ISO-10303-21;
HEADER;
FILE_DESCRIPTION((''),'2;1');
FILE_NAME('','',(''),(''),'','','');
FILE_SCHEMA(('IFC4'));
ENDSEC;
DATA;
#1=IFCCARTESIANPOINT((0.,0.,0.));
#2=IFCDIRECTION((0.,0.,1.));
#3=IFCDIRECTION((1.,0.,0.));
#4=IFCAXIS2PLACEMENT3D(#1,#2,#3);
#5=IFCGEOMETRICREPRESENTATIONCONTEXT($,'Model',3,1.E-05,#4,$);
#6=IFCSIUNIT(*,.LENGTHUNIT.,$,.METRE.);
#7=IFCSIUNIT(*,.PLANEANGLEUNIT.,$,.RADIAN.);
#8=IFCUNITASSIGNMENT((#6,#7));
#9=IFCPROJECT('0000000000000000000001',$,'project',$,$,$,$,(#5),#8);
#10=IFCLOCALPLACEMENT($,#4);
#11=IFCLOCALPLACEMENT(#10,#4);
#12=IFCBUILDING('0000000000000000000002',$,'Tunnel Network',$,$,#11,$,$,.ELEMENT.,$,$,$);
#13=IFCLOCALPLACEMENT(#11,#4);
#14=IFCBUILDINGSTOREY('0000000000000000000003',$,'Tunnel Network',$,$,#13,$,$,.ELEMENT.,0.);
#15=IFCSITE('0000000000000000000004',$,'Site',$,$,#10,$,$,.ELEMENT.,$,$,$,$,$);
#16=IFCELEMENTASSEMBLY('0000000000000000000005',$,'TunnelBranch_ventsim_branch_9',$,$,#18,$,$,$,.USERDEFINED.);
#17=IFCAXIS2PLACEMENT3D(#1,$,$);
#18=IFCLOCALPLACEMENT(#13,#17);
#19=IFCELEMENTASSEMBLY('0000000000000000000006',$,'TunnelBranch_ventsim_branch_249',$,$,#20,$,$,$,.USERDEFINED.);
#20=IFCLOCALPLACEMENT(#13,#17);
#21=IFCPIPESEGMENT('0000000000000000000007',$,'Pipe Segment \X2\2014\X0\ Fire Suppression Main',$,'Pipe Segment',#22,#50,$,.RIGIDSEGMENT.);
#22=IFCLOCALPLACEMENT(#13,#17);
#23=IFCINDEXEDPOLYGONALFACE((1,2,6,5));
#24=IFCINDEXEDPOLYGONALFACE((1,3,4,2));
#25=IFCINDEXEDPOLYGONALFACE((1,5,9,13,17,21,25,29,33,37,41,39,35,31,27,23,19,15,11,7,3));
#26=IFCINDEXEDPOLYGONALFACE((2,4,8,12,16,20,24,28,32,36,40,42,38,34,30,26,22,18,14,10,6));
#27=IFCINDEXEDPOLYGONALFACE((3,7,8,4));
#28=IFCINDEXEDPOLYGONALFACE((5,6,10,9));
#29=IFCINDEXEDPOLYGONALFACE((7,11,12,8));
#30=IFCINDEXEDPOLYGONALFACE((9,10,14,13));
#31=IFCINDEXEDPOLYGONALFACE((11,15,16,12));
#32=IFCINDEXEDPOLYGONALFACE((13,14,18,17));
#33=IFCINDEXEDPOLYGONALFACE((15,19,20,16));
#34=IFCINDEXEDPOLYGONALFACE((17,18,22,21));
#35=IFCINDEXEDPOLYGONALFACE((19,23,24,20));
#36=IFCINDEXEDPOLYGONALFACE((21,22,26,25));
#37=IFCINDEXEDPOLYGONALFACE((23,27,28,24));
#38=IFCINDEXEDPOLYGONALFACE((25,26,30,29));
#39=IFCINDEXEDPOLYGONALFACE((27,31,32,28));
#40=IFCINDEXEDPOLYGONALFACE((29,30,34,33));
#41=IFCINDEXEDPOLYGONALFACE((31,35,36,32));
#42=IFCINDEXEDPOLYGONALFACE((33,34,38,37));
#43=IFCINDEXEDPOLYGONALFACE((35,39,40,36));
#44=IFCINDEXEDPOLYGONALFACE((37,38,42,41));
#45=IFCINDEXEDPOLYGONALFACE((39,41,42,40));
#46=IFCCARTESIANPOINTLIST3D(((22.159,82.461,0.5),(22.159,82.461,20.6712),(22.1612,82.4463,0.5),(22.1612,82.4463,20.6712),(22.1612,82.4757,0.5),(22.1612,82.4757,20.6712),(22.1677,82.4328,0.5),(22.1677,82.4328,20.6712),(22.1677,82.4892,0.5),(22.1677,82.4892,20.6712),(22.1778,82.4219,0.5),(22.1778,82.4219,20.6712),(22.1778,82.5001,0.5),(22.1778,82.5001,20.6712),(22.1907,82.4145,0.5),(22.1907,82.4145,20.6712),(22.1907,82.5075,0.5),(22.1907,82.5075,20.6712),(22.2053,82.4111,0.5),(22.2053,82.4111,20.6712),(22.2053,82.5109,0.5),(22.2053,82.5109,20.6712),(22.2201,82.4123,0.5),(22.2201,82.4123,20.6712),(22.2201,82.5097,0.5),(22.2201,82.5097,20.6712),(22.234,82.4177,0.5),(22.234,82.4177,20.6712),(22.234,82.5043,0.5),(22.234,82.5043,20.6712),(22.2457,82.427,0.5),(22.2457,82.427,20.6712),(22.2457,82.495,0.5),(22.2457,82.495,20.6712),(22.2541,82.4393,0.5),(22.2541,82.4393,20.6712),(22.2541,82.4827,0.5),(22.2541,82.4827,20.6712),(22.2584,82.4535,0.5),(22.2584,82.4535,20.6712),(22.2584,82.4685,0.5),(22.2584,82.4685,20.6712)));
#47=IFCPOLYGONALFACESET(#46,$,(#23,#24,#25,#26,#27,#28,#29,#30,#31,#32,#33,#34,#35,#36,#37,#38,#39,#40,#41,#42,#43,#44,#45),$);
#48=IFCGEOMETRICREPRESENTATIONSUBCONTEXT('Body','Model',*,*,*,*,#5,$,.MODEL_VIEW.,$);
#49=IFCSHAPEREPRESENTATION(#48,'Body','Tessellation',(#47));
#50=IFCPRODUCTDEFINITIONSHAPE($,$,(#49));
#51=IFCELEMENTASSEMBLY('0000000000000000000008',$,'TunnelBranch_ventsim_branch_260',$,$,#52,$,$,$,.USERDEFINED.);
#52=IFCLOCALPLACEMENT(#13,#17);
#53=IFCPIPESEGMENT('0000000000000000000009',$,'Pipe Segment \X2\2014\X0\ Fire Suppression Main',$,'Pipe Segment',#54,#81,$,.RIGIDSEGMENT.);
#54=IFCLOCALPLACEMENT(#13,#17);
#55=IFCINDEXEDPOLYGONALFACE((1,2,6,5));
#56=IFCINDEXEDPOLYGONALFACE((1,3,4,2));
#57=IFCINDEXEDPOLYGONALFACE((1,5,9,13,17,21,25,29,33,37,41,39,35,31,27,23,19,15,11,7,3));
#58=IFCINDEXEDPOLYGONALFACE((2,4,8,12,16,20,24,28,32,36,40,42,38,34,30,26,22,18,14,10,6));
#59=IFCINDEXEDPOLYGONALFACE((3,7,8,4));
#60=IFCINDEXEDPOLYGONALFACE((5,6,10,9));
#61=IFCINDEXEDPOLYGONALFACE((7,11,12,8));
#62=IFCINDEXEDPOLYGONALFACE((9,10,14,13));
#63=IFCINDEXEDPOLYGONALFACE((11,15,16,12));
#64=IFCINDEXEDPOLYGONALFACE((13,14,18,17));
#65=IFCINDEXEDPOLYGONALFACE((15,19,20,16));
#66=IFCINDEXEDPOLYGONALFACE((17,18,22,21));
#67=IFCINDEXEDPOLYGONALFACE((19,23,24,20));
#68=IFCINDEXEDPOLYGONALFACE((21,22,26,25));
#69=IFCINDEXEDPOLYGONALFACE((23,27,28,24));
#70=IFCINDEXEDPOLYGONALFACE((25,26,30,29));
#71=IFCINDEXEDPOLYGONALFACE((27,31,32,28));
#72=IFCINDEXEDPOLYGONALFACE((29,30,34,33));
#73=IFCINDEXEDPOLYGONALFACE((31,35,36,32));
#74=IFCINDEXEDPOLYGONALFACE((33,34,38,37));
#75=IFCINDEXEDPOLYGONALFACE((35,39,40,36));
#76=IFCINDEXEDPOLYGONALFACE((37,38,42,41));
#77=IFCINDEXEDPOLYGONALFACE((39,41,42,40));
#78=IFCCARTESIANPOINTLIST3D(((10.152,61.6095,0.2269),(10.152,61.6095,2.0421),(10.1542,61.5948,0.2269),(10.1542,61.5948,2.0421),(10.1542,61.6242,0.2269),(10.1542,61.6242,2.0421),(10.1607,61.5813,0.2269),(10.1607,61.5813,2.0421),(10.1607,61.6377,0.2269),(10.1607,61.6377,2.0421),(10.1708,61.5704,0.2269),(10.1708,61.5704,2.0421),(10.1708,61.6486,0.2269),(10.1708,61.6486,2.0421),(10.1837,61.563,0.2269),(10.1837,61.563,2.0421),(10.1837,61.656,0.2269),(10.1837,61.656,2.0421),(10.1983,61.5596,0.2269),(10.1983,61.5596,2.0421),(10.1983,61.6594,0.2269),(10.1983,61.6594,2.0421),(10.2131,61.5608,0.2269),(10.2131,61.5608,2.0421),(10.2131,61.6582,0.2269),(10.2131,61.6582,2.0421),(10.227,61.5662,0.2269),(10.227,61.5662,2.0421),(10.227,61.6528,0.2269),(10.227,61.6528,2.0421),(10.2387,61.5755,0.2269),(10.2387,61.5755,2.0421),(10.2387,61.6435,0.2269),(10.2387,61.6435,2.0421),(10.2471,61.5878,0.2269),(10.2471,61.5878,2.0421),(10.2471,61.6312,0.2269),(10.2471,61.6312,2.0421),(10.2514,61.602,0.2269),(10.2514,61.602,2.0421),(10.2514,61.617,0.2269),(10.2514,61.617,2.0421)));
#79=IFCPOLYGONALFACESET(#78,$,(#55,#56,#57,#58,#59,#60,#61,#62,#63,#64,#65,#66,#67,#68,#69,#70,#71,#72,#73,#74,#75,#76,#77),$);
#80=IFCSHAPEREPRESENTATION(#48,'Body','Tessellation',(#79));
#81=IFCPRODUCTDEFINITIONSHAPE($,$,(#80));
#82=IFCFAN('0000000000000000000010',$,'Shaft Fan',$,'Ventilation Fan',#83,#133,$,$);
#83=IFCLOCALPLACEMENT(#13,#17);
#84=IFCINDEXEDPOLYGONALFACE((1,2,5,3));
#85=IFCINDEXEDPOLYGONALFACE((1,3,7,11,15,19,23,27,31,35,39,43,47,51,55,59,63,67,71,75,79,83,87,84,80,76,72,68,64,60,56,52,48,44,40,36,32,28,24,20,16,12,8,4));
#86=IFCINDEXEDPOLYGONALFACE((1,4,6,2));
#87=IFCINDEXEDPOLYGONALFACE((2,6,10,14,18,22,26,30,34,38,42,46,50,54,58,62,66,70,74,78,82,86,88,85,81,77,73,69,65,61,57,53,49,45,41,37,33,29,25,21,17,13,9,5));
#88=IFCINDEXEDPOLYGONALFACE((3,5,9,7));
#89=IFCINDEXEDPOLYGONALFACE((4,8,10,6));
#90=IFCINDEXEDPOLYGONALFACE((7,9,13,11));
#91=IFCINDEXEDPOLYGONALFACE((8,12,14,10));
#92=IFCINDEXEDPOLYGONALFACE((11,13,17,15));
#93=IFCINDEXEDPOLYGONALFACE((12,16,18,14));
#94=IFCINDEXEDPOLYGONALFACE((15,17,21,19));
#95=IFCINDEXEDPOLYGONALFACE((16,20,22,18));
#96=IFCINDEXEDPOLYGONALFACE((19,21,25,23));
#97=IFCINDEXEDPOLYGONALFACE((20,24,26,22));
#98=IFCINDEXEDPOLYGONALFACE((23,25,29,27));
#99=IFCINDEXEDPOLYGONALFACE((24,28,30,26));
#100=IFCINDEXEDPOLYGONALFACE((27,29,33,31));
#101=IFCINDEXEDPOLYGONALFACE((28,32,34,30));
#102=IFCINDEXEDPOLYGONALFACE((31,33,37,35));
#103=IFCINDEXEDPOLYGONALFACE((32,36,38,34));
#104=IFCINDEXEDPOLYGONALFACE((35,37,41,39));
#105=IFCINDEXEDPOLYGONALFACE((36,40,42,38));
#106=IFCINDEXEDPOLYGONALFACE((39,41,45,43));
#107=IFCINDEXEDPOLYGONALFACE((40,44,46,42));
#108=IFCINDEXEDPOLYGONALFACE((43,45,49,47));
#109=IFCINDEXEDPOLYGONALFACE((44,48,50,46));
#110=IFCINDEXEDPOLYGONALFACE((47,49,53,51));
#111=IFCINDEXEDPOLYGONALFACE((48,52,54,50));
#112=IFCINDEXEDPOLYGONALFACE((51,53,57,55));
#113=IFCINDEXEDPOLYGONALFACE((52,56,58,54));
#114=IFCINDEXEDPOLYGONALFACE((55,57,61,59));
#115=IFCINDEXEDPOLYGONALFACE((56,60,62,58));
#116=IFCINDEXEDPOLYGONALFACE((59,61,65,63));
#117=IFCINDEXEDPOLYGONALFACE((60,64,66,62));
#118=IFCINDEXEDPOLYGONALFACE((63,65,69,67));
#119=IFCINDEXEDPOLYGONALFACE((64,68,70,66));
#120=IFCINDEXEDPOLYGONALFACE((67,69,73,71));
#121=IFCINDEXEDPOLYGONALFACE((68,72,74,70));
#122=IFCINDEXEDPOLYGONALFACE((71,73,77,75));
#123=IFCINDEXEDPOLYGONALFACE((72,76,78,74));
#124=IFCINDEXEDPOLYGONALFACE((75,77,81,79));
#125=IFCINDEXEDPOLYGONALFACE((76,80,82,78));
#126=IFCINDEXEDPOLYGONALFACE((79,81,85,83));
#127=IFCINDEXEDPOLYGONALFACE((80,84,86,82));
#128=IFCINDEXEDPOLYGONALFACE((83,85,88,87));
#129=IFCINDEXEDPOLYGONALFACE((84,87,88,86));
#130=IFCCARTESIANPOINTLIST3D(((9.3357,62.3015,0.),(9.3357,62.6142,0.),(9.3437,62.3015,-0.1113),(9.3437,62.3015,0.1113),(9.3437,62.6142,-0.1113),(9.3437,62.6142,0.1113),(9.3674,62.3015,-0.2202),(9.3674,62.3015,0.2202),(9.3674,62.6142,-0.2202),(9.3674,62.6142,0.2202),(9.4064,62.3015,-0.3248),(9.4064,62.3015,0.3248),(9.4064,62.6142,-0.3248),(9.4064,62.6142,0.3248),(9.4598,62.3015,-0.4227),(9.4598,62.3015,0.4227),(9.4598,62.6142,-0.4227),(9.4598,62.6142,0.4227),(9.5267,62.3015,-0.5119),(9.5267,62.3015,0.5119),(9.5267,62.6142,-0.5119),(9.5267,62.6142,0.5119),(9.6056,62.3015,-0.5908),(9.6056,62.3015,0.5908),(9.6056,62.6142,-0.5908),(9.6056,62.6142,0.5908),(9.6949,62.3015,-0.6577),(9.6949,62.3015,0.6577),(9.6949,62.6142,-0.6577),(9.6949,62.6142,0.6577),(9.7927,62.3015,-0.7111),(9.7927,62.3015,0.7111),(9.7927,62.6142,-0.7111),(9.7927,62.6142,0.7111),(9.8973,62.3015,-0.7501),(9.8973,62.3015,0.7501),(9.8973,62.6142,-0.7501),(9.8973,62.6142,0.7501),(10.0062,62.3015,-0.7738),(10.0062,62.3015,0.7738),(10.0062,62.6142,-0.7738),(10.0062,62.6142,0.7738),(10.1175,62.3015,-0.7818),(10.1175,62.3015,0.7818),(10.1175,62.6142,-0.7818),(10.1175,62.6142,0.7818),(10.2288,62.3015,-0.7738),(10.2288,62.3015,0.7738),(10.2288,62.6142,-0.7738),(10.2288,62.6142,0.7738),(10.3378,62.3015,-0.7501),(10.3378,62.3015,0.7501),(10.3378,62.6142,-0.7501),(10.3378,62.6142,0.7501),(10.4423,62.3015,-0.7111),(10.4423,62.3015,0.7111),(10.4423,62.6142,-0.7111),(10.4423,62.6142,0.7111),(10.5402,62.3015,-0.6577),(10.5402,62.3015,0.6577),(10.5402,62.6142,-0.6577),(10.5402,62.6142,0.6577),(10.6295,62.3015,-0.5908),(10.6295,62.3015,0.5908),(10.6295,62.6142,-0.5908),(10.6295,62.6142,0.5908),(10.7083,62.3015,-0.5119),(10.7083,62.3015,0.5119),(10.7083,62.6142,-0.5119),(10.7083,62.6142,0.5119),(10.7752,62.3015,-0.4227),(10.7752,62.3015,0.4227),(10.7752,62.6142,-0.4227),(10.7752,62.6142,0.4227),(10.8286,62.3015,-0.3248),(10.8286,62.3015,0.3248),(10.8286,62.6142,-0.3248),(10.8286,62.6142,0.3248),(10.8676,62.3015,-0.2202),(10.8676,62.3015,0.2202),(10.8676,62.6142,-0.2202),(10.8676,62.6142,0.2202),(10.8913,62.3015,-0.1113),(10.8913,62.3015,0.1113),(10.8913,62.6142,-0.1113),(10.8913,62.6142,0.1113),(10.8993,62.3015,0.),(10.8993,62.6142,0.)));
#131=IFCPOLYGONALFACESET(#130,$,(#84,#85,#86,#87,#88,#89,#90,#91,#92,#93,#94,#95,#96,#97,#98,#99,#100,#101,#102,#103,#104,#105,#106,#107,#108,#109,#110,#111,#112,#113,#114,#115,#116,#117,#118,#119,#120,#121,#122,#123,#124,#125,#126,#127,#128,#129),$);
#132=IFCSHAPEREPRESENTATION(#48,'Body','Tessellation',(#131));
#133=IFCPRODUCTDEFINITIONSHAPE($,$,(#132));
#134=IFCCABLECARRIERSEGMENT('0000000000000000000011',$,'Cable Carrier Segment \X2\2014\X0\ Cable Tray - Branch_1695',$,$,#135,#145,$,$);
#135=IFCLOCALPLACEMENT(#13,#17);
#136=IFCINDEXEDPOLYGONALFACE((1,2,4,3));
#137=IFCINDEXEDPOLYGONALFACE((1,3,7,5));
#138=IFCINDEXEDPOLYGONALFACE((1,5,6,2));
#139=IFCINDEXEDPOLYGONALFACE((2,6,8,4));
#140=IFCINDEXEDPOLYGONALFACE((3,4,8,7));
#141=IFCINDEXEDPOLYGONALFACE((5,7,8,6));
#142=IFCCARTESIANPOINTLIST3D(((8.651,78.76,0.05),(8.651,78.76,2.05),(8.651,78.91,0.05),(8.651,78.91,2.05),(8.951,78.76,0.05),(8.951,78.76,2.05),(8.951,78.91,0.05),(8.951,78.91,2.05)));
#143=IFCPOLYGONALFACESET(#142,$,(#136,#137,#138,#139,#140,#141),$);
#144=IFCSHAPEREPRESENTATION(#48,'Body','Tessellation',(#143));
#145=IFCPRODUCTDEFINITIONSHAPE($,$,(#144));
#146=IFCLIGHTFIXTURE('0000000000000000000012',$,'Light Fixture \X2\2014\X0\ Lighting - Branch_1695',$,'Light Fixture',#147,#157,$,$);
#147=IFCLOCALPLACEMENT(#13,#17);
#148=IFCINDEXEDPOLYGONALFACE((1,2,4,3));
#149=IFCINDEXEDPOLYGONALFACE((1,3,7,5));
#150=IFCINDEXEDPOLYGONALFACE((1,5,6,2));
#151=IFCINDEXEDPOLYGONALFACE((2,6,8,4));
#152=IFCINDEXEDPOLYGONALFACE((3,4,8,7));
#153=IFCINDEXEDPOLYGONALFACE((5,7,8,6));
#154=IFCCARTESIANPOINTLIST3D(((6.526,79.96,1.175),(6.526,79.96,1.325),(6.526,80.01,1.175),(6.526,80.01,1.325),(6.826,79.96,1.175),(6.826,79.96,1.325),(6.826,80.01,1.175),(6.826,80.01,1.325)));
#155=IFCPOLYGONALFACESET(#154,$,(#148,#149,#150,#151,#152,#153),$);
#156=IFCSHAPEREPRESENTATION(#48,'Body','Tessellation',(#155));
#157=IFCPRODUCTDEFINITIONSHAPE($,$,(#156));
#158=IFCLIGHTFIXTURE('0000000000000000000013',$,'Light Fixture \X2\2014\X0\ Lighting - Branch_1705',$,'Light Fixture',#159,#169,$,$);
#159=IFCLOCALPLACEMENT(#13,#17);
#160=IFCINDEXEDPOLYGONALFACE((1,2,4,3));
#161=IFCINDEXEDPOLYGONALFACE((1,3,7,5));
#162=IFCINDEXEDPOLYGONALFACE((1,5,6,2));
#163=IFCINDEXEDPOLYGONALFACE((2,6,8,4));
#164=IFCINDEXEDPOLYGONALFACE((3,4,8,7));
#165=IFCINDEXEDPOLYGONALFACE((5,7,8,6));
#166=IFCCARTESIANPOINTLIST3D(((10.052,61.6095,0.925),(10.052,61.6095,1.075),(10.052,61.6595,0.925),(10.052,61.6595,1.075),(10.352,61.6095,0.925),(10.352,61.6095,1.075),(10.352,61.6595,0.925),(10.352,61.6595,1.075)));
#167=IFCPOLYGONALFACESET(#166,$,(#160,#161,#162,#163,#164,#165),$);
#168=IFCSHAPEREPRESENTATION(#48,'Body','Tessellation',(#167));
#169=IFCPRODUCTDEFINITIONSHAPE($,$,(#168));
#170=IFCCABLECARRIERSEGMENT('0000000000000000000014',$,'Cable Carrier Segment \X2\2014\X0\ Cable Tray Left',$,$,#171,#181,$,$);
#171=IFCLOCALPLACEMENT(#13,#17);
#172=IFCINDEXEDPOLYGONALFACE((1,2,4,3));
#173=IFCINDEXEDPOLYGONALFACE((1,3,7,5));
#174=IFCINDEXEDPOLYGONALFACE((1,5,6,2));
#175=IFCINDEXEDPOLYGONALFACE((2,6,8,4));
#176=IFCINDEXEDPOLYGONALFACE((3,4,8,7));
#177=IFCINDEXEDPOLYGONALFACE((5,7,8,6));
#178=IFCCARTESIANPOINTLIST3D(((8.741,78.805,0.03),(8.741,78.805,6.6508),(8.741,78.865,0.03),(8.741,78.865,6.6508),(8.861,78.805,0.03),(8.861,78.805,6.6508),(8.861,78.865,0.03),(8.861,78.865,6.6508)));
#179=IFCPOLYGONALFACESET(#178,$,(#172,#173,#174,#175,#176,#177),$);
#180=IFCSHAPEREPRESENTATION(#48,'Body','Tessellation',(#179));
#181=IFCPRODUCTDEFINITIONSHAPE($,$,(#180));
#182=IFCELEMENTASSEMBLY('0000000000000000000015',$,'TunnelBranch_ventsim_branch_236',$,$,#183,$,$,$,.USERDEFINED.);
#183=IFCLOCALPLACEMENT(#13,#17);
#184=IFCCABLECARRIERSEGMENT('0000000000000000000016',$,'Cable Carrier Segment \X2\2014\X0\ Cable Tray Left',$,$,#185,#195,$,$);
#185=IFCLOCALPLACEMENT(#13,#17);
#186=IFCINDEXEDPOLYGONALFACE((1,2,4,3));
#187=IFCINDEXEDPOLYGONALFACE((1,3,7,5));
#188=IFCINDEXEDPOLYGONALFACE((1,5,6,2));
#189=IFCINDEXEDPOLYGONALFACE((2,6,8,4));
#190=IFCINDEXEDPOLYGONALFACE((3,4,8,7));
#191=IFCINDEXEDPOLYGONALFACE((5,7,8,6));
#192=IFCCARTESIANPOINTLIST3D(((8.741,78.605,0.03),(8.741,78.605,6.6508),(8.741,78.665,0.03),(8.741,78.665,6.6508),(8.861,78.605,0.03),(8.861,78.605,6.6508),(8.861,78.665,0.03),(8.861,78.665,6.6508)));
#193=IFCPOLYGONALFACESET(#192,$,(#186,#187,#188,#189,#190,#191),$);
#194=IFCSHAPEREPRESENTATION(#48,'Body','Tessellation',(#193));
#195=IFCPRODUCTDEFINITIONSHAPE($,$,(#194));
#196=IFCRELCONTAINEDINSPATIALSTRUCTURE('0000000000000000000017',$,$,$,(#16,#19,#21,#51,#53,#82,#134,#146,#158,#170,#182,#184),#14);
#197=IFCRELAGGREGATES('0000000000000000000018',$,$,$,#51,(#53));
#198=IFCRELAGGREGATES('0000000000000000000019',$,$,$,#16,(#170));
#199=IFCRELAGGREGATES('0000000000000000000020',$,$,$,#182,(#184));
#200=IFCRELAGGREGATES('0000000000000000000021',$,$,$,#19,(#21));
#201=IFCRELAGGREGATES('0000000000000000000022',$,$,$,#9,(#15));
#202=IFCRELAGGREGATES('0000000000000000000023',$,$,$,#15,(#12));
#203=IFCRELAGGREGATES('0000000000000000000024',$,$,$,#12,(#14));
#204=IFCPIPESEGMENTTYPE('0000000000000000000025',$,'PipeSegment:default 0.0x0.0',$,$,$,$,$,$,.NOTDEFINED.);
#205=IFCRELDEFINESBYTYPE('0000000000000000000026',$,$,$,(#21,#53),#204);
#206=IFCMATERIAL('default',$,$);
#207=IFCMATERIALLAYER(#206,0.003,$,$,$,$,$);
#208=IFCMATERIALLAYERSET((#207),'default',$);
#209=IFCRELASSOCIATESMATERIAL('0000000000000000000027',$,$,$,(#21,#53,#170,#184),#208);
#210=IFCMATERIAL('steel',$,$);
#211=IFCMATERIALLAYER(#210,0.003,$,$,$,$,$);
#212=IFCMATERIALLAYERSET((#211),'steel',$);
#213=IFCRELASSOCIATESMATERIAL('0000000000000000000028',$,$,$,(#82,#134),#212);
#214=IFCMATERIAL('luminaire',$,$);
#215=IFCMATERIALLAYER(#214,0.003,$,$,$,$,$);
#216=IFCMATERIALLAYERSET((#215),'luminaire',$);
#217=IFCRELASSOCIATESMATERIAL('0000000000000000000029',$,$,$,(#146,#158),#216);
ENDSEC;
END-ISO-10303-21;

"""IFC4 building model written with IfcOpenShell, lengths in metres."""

from ifc_helpers import new_model, si_unit, frame, origin_with_axes, origin_2d_with_axis, place, context, subcontext, project, spatial, rectangle, circle, extrude, material, layer, layer_set, layer_usage, type_object, element, aggregate, save


model = new_model("IFC4")

# Units and contexts
model_context = context("Model", 3, precision=1e-05, world=origin_with_axes())
body_context = subcontext(model_context, "Body", "Model", "MODEL_VIEW")
ifc_project = project(units=[si_unit("LENGTHUNIT", "METRE"), si_unit("PLANEANGLEUNIT", "RADIAN")], contexts=[model_context])

# Site, building, storey
site_placement = place(None, origin_with_axes())
site = spatial("IfcSite", under=ifc_project, at=site_placement, Name="Site", CompositionType="ELEMENT")
building_placement = place(site_placement, origin_with_axes())
building = spatial("IfcBuilding", under=site, at=building_placement, Name="Tunnel Network", CompositionType="ELEMENT")
storey_placement = place(building_placement, origin_with_axes())
storey = spatial("IfcBuildingStorey", under=building, at=storey_placement, Name="Tunnel Network", CompositionType="ELEMENT", Elevation=0.0)

# Element assemblies, pipe segments
assembly_1_placement = place(storey_placement, frame((6.676, 79.96, 0.8276), z_axis=(0.0, 0.0, 1.0), x_axis=(-1.0, 0.0, 0.0)))
assembly_1 = element("IfcElementAssembly", 1, at=assembly_1_placement, inside=storey, Name="TunnelBranch_ventsim_branch_9", PredefinedType="USERDEFINED")
ifc_material_1 = material(Name="default")
ifc_layer_1 = layer(ifc_material_1, 0.003)
ifc_layer_set_1 = layer_set([ifc_layer_1], Name="default")
pipe_segment_type = type_object("IfcPipeSegmentType", Name="PipeSegment:default 0.0x0.0")
assembly_2_placement = place(storey_placement, frame((22.209, 82.461, 1.0), z_axis=(0.0, 1.0, 0.0), x_axis=(-1.0, 0.0, 0.0)))
assembly_2 = element("IfcElementAssembly", 2, at=assembly_2_placement, inside=storey, Name="TunnelBranch_ventsim_branch_249", PredefinedType="USERDEFINED")
ifc_layer_usage_1 = layer_usage(ifc_layer_set_1, "AXIS2", "POSITIVE", 0.0)
pipe_segment_1_placement = place(storey_placement, frame((22.209, 82.461, 0.5), z_axis=(0.0, 0.0, 1.0), x_axis=(-1.0, 0.0, 0.0)))
pipe_segment_1 = element("IfcPipeSegment", 3, at=pipe_segment_1_placement, inside=storey, type_object=pipe_segment_type, material=ifc_layer_usage_1, Name="Pipe Segment — Fire Suppression Main", ObjectType="Pipe Segment", PredefinedType="RIGIDSEGMENT", context=body_context, shape_type="SweptSolid", body=[
    extrude(circle(Radius=0.05, at=origin_2d_with_axis()), origin_with_axes(), (0.0, 0.0, 1.0), 20.1712),
])
assembly_3_placement = place(storey_placement, frame((7.702, 59.9095, 0.1135), z_axis=(0.0, 1.0, 0.0), x_axis=(-1.0, 0.0, 0.0)))
assembly_3 = element("IfcElementAssembly", 4, at=assembly_3_placement, inside=storey, Name="TunnelBranch_ventsim_branch_260", PredefinedType="USERDEFINED")
ifc_layer_usage_2 = layer_usage(ifc_layer_set_1, "AXIS2", "POSITIVE", 0.0)
pipe_segment_2_placement = place(storey_placement, frame((10.202, 61.6095, 0.2269), z_axis=(0.0, 0.0, 1.0), x_axis=(-1.0, 0.0, 0.0)))
pipe_segment_2 = element("IfcPipeSegment", 5, at=pipe_segment_2_placement, inside=storey, type_object=pipe_segment_type, material=ifc_layer_usage_2, Name="Pipe Segment — Fire Suppression Main", ObjectType="Pipe Segment", PredefinedType="RIGIDSEGMENT", context=body_context, shape_type="SweptSolid", body=[
    extrude(circle(Radius=0.05, at=origin_2d_with_axis()), origin_with_axes(), (0.0, 0.0, 1.0), 1.8152),
])
aggregate(assembly_3, [pipe_segment_2])

# Fan
ifc_material_2 = material(Name="steel")
ifc_layer_2 = layer(ifc_material_2, 0.003)
ifc_layer_set_2 = layer_set([ifc_layer_2], Name="steel")
ifc_layer_usage_3 = layer_usage(ifc_layer_set_2, "AXIS2", "POSITIVE", 0.0)
fan_placement = place(storey_placement, frame((10.1175, 62.3015, 0.0), z_axis=(0.0, 1.0, 0.0), x_axis=(-1.0, 0.0, 0.0)))
element("IfcFan", 6, at=fan_placement, inside=storey, material=ifc_layer_usage_3, Name="Shaft Fan", ObjectType="Ventilation Fan", context=body_context, shape_type="SweptSolid", body=[
    extrude(circle(Radius=0.7818, at=origin_2d_with_axis()), origin_with_axes(), (0.0, 0.0, 1.0), 0.3127),
])

# Cable carrier segment
ifc_layer_usage_4 = layer_usage(ifc_layer_set_2, "AXIS2", "POSITIVE", 0.0)
cable_carrier_segment_1_placement = place(storey_placement, frame((8.801, 78.835, 0.05), z_axis=(0.0, 0.0, 1.0), x_axis=(-1.0, 0.0, 0.0)))
element("IfcCableCarrierSegment", 7, at=cable_carrier_segment_1_placement, inside=storey, material=ifc_layer_usage_4, Name="Cable Carrier Segment — Cable Tray - Branch_1695", context=body_context, shape_type="SweptSolid", body=[
    extrude(rectangle(XDim=0.3, YDim=0.15, at=origin_2d_with_axis()), origin_with_axes(), (0.0, 0.0, 1.0), 2.0),
])

# Light fixture
ifc_material_3 = material(Name="luminaire")
ifc_layer_3 = layer(ifc_material_3, 0.003)
ifc_layer_set_3 = layer_set([ifc_layer_3], Name="luminaire")
ifc_layer_usage_5 = layer_usage(ifc_layer_set_3, "AXIS2", "POSITIVE", 0.0)
light_fixture_1_placement = place(storey_placement, frame((6.676, 79.96, 1.25), z_axis=(0.0, 1.0, 0.0), x_axis=(-1.0, 0.0, 0.0)))
element("IfcLightFixture", 8, at=light_fixture_1_placement, inside=storey, material=ifc_layer_usage_5, Name="Light Fixture — Lighting - Branch_1695", ObjectType="Light Fixture", context=body_context, shape_type="SweptSolid", body=[
    extrude(rectangle(XDim=0.3, YDim=0.15, at=origin_2d_with_axis()), origin_with_axes(), (0.0, 0.0, 1.0), 0.05),
])

# Light fixture
ifc_layer_usage_6 = layer_usage(ifc_layer_set_3, "AXIS2", "POSITIVE", 0.0)
light_fixture_2_placement = place(storey_placement, frame((10.202, 61.6095, 1.0), z_axis=(0.0, 1.0, 0.0), x_axis=(-1.0, 0.0, 0.0)))
element("IfcLightFixture", 9, at=light_fixture_2_placement, inside=storey, material=ifc_layer_usage_6, Name="Light Fixture — Lighting - Branch_1705", ObjectType="Light Fixture", context=body_context, shape_type="SweptSolid", body=[
    extrude(rectangle(XDim=0.3, YDim=0.15, at=origin_2d_with_axis()), origin_with_axes(), (0.0, 0.0, 1.0), 0.05),
])

# Cable carrier segment
ifc_layer_usage_7 = layer_usage(ifc_layer_set_1, "AXIS2", "POSITIVE", 0.0)
cable_carrier_segment_2_placement = place(storey_placement, frame((8.801, 78.835, 0.03), z_axis=(0.0, 0.0, 1.0), x_axis=(-1.0, 0.0, 0.0)))
cable_carrier_segment_2 = element("IfcCableCarrierSegment", 10, at=cable_carrier_segment_2_placement, inside=storey, material=ifc_layer_usage_7, Name="Cable Carrier Segment — Cable Tray Left", context=body_context, shape_type="SweptSolid", body=[
    extrude(rectangle(XDim=0.12, YDim=0.06, at=origin_2d_with_axis()), origin_with_axes(), (0.0, 0.0, 1.0), 6.6208),
])
aggregate(assembly_1, [cable_carrier_segment_2])

# Element assembly, cable carrier segment
assembly_4_placement = place(storey_placement, frame((6.676, 79.535, 1.25), z_axis=(0.0, 1.0, 0.0), x_axis=(-1.0, 0.0, 0.0)))
assembly_4 = element("IfcElementAssembly", 11, at=assembly_4_placement, inside=storey, Name="TunnelBranch_ventsim_branch_236", PredefinedType="USERDEFINED")
ifc_layer_usage_8 = layer_usage(ifc_layer_set_1, "AXIS2", "POSITIVE", 0.0)
cable_carrier_segment_3_placement = place(storey_placement, frame((8.801, 78.635, 0.03), z_axis=(0.0, 0.0, 1.0), x_axis=(-1.0, 0.0, 0.0)))
cable_carrier_segment_3 = element("IfcCableCarrierSegment", 12, at=cable_carrier_segment_3_placement, inside=storey, material=ifc_layer_usage_8, Name="Cable Carrier Segment — Cable Tray Left", context=body_context, shape_type="SweptSolid", body=[
    extrude(rectangle(XDim=0.12, YDim=0.06, at=origin_2d_with_axis()), origin_with_axes(), (0.0, 0.0, 1.0), 6.6208),
])
aggregate(assembly_4, [cable_carrier_segment_3])

aggregate(assembly_2, [pipe_segment_1])

save(model, "model.ifc")
